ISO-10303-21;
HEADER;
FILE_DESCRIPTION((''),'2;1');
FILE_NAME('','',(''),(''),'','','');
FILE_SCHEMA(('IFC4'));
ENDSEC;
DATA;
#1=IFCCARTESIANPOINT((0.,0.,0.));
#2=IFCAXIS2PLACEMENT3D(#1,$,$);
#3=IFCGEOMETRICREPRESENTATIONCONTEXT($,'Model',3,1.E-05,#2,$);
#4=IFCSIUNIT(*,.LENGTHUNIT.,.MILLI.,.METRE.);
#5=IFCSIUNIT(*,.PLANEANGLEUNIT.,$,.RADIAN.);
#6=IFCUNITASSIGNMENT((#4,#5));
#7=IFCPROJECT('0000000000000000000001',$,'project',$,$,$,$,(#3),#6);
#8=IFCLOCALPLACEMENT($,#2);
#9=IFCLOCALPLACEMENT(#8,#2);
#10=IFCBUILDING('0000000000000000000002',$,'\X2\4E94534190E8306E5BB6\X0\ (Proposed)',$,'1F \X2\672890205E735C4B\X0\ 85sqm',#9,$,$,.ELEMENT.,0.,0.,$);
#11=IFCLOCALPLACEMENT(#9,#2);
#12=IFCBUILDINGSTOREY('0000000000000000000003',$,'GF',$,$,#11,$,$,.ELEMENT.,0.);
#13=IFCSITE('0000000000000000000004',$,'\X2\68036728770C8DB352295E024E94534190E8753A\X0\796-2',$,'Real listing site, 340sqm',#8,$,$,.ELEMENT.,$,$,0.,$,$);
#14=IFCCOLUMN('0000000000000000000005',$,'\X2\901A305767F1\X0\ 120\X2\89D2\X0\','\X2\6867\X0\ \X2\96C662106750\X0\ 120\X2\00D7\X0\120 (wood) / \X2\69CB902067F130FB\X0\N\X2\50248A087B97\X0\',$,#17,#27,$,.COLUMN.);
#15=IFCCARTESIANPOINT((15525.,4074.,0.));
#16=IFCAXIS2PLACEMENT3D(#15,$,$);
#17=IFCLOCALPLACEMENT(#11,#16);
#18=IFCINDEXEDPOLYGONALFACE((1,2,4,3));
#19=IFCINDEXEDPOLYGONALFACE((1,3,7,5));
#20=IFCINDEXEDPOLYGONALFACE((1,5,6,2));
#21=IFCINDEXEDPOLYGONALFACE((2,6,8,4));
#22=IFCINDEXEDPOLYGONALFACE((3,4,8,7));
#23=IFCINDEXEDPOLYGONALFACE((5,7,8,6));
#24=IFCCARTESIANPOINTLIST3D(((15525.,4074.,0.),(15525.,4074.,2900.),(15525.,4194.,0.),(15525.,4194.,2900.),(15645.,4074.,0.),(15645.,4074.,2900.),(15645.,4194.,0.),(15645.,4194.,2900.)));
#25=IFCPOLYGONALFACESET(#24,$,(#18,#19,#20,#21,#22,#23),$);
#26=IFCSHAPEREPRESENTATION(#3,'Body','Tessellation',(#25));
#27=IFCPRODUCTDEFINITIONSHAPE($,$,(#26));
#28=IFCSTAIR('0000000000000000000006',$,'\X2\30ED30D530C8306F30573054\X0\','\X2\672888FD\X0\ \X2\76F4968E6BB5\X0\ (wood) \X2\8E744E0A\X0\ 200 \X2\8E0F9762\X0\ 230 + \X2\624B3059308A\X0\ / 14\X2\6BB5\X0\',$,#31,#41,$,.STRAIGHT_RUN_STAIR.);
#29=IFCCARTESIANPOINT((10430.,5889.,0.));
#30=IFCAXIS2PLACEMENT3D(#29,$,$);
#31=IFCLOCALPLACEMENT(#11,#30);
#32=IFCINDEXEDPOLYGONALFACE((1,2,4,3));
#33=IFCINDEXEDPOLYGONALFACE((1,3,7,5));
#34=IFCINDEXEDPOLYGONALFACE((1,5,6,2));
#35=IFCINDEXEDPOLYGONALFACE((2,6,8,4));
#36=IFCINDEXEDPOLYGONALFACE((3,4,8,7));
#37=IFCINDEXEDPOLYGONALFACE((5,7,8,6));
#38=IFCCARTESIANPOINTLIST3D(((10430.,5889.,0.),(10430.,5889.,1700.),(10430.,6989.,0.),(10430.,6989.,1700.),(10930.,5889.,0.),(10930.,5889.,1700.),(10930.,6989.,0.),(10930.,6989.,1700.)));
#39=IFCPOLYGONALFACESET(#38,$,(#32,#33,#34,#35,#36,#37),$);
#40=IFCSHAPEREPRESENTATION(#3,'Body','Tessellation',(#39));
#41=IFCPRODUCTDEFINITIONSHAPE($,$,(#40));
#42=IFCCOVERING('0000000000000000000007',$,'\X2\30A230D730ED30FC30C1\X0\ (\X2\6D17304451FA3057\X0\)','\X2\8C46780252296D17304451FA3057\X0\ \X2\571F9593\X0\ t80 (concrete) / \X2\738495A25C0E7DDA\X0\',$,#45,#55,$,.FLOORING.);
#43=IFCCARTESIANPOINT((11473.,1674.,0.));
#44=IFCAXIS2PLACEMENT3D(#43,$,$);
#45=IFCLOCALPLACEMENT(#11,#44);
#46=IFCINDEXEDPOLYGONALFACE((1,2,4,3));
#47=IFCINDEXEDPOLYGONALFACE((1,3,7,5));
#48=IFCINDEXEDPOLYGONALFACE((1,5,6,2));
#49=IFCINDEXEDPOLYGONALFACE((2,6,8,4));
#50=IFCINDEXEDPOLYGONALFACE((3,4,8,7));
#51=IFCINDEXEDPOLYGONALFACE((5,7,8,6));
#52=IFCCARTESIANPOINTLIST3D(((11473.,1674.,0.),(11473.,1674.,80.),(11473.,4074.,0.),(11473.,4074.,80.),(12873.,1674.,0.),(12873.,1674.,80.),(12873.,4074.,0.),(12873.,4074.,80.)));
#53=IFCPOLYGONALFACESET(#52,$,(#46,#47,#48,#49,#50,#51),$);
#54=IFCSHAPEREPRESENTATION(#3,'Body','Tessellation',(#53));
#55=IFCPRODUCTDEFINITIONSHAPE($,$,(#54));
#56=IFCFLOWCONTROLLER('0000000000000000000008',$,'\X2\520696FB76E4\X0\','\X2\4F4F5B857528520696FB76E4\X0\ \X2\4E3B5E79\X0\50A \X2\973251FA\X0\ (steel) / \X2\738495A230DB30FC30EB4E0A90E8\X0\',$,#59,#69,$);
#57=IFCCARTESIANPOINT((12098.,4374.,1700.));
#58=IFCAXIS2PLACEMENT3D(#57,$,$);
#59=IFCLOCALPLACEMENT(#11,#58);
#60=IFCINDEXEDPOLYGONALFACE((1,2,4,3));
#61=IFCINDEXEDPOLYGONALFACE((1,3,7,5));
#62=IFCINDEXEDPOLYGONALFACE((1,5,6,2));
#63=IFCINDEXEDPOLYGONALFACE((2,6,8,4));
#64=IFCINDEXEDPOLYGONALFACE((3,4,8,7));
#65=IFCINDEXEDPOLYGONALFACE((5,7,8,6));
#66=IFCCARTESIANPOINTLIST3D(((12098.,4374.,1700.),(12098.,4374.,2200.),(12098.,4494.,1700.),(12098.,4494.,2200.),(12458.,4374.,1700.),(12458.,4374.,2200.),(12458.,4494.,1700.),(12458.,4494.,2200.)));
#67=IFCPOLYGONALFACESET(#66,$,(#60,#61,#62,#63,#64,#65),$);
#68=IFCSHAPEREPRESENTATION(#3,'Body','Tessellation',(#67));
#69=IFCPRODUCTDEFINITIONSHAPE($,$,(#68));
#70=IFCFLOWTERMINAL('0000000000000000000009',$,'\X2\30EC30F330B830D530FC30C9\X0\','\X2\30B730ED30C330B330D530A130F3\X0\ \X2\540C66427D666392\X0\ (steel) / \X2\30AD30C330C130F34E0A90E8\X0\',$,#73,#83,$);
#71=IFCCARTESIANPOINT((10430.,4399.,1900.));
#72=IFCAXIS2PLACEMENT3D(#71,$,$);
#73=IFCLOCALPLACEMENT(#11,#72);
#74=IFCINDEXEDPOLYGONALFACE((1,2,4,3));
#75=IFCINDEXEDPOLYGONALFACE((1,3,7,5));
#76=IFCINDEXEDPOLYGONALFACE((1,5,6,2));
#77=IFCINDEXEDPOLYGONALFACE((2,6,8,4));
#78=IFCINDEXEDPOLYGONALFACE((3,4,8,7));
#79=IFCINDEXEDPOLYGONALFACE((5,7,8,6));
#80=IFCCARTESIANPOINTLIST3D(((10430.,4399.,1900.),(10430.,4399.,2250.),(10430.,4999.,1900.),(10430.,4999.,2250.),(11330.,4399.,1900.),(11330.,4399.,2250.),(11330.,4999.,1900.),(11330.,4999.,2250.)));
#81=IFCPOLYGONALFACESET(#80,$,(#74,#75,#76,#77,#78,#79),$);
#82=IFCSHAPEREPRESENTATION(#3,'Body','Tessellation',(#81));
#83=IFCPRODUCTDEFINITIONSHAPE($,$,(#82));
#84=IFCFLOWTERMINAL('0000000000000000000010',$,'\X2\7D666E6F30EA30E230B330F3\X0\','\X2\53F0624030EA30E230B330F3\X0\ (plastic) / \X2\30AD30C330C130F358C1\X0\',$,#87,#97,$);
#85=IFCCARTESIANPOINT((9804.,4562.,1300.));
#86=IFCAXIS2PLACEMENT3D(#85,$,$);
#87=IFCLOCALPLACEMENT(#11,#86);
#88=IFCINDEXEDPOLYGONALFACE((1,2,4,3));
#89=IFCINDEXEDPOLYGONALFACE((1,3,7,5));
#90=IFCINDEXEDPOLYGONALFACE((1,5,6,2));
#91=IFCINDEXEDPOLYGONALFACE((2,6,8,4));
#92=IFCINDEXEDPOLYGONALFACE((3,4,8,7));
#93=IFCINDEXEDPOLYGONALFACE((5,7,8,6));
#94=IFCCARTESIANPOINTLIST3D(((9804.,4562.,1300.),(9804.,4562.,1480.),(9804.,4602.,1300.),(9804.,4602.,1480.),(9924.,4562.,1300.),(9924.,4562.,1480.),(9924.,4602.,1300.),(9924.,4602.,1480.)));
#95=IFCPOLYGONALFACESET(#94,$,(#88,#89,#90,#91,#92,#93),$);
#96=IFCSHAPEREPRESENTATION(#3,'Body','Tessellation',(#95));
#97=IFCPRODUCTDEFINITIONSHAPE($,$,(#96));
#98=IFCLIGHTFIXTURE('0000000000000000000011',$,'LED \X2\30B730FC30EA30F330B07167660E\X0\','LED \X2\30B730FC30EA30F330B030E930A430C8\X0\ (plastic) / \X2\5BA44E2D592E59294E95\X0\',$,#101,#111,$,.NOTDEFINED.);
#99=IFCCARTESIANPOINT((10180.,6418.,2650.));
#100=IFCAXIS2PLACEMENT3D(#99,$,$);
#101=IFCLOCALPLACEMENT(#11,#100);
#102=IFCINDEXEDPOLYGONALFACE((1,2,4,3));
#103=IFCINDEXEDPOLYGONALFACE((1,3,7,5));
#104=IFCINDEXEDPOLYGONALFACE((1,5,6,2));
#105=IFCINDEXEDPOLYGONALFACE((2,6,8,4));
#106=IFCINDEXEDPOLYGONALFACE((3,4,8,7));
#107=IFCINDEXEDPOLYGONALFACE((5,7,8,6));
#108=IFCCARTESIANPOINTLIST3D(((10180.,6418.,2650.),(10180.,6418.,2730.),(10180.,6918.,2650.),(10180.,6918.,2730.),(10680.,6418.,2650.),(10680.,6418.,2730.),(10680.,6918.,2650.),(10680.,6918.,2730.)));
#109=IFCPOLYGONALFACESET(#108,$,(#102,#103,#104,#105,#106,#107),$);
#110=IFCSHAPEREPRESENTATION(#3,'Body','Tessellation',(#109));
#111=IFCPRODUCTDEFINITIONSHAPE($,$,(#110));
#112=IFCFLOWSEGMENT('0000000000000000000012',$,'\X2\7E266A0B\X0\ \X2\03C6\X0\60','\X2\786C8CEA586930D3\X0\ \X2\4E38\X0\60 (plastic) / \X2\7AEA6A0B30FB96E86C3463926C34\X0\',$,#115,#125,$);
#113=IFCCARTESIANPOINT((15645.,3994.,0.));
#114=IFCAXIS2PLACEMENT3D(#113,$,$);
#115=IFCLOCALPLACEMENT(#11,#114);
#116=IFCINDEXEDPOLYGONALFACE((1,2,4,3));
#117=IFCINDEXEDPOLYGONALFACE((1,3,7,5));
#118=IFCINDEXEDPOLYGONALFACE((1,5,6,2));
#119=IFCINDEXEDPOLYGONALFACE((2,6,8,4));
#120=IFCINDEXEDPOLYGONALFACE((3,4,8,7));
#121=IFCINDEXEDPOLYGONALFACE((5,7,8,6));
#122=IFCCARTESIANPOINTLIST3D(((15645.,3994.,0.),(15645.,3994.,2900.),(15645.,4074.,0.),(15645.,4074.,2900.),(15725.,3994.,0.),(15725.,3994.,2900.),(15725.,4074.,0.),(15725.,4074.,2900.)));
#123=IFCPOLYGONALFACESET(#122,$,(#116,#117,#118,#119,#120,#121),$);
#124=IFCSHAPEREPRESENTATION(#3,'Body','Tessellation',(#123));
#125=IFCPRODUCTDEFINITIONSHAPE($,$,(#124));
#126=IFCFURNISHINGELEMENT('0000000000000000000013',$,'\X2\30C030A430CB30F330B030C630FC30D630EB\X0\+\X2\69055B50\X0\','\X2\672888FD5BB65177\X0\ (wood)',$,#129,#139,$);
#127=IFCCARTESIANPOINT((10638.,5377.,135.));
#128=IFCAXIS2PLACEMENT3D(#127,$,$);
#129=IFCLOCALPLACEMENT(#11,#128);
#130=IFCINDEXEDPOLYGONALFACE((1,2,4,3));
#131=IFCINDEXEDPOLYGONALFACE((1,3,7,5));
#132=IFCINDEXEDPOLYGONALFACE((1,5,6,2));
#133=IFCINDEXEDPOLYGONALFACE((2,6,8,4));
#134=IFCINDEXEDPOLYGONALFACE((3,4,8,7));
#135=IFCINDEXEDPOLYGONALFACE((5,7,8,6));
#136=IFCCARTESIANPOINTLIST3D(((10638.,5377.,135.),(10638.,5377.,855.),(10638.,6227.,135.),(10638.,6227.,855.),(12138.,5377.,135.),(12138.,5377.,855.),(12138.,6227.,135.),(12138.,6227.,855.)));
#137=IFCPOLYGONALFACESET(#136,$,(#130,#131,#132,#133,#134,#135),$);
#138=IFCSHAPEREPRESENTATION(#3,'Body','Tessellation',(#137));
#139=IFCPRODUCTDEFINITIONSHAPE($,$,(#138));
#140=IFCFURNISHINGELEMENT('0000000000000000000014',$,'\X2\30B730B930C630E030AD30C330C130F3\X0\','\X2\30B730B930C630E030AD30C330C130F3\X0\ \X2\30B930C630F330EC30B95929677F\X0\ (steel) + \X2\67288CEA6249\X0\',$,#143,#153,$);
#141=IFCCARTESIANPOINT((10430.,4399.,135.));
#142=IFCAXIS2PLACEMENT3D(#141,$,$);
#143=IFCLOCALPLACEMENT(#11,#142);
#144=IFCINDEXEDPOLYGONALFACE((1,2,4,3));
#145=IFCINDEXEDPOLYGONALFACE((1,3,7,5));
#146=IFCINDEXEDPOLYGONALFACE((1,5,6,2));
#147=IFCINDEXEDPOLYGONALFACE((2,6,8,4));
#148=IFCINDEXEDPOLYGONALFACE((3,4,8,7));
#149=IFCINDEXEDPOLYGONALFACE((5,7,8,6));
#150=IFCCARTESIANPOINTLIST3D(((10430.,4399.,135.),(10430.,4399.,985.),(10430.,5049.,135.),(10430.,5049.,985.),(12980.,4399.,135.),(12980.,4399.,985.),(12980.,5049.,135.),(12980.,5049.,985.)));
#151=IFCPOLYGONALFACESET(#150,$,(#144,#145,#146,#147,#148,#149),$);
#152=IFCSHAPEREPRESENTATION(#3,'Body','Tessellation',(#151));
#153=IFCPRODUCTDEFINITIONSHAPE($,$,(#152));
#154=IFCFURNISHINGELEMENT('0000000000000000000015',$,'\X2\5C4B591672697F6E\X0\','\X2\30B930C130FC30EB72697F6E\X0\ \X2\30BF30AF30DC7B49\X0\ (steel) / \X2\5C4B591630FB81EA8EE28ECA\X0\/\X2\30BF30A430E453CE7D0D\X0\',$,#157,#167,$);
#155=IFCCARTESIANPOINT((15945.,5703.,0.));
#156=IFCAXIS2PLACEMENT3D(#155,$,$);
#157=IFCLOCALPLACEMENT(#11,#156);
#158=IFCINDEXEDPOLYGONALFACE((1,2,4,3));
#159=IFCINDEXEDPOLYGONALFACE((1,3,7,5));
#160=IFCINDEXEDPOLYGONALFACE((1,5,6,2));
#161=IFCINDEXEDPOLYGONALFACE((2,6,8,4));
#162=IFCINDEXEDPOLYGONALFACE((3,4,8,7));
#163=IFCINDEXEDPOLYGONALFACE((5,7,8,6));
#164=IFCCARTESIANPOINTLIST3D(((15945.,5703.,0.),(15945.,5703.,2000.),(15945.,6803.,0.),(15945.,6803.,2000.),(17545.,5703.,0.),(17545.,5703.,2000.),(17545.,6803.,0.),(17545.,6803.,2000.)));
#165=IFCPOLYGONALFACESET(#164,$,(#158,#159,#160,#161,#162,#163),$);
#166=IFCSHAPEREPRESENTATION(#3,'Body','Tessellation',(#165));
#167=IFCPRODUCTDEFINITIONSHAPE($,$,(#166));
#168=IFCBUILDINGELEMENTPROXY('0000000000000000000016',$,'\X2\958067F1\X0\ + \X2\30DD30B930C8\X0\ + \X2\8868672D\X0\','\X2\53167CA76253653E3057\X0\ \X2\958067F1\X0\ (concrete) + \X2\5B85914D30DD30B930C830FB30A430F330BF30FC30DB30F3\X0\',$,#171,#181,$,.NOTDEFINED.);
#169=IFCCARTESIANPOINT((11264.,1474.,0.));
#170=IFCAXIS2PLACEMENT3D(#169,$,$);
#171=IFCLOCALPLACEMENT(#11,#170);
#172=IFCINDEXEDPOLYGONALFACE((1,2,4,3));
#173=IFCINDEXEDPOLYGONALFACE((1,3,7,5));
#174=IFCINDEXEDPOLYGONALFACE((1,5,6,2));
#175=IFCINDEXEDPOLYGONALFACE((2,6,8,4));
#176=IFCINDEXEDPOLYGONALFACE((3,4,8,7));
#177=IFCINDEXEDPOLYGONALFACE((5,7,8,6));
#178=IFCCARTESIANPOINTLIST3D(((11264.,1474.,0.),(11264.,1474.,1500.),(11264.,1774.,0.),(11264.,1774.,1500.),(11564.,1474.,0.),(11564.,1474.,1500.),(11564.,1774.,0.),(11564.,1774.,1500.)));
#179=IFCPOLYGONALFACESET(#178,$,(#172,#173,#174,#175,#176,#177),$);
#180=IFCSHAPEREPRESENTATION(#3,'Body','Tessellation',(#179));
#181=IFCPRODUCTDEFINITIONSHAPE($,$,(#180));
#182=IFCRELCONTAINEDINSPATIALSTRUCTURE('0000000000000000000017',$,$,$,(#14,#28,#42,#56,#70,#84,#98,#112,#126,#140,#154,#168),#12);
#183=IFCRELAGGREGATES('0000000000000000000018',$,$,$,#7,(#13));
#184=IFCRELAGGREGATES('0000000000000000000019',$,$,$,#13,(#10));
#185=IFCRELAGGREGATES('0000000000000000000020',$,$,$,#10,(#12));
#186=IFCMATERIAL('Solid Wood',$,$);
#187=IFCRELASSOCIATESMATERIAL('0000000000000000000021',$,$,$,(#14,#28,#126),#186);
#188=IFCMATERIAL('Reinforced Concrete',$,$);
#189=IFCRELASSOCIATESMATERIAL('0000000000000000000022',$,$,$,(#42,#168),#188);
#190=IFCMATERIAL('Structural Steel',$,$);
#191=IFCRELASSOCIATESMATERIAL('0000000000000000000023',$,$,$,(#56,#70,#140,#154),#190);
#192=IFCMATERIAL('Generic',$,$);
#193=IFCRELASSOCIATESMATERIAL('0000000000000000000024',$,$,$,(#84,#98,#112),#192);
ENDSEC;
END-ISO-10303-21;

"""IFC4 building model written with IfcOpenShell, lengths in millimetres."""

from ifc_helpers import new_model, si_unit, frame, frame_2d, origin, place, context, project, spatial, rectangle, extrude, material, element, save


model = new_model("IFC4")

# Units and contexts
model_context = context("Model", 3, precision=1e-05, world=origin())
ifc_project = project(units=[si_unit("LENGTHUNIT", "METRE", prefix="MILLI"), si_unit("PLANEANGLEUNIT", "RADIAN")], contexts=[model_context])

# Site, building, storey
site_placement = place(None, origin())
site = spatial("IfcSite", under=ifc_project, at=site_placement, Name="栃木県足利市五十部町796-2", ObjectType="Real listing site, 340sqm", CompositionType="ELEMENT", RefElevation=0.0)
building_placement = place(site_placement, origin())
building = spatial("IfcBuilding", under=site, at=building_placement, Name="五十部の家 (Proposed)", ObjectType="1F 木造平屋 85sqm", CompositionType="ELEMENT", ElevationOfRefHeight=0.0, ElevationOfTerrain=0.0)
storey_placement = place(building_placement, origin())
storey = spatial("IfcBuildingStorey", under=building, at=storey_placement, Name="GF", CompositionType="ELEMENT", Elevation=0.0)

# Column
ifc_material_1 = material(Name="Solid Wood")
column_1_placement = place(storey_placement, frame((15525.0, 4074.0, 0.0)))
element("IfcColumn", 1, at=column_1_placement, inside=storey, material=ifc_material_1, Name="通し柱 120角", Description="桧 集成材 120×120 (wood) / 構造柱・N値計算", PredefinedType="COLUMN", context=model_context, shape_type="SweptSolid", body=[
    extrude(rectangle(XDim=120.0, YDim=120.0, at=frame_2d((60.0, 60.0))), frame((15525.0, 4074.0, 0.0)), (0.0, 0.0, 1.0), 2900.0),
])

# Stair
stair_placement = place(storey_placement, frame((10430.0, 5889.0, 0.0)))
element("IfcStair", 2, at=stair_placement, inside=storey, material=ifc_material_1, Name="ロフトはしご", Description="木製 直階段 (wood) 蹴上 200 踏面 230 + 手すり / 14段", PredefinedType="STRAIGHT_RUN_STAIR", context=model_context, shape_type="SweptSolid", body=[
    extrude(rectangle(XDim=500.0, YDim=1100.0, at=frame_2d((250.0, 550.0))), frame((10430.0, 5889.0, 0.0)), (0.0, 0.0, 1.0), 1700.0),
])

# Covering
ifc_material_2 = material(Name="Reinforced Concrete")
covering_placement = place(storey_placement, frame((11473.0, 1674.0, 0.0)))
element("IfcCovering", 3, at=covering_placement, inside=storey, material=ifc_material_2, Name="アプローチ (洗い出し)", Description="豆砂利洗い出し 土間 t80 (concrete) / 玄関導線", PredefinedType="FLOORING", context=model_context, shape_type="SweptSolid", body=[
    extrude(rectangle(XDim=1400.0, YDim=2400.0, at=frame_2d((700.0, 1200.0))), frame((11473.0, 1674.0, 0.0)), (0.0, 0.0, 1.0), 80.0),
])

# Flow controller
ifc_material_3 = material(Name="Structural Steel")
flow_controller_placement = place(storey_placement, frame((12098.0, 4374.0, 1700.0)))
element("IfcFlowController", 4, at=flow_controller_placement, inside=storey, material=ifc_material_3, Name="分電盤", Description="住宅用分電盤 主幹50A 露出 (steel) / 玄関ホール上部", context=model_context, shape_type="SweptSolid", body=[
    extrude(rectangle(XDim=360.0, YDim=120.0, at=frame_2d((180.0, 60.0))), frame((12098.0, 4374.0, 1700.0)), (0.0, 0.0, 1.0), 500.0),
])

# Flow terminals
flow_terminal_1_placement = place(storey_placement, frame((10430.0, 4399.0, 1900.0)))
element("IfcFlowTerminal", 5, at=flow_terminal_1_placement, inside=storey, material=ifc_material_3, Name="レンジフード", Description="シロッコファン 同時給排 (steel) / キッチン上部", context=model_context, shape_type="SweptSolid", body=[
    extrude(rectangle(XDim=900.0, YDim=600.0, at=frame_2d((450.0, 300.0))), frame((10430.0, 4399.0, 1900.0)), (0.0, 0.0, 1.0), 350.0),
])
ifc_material_4 = material(Name="Generic")
flow_terminal_2_placement = place(storey_placement, frame((9804.0, 4562.0, 1300.0)))
element("IfcFlowTerminal", 6, at=flow_terminal_2_placement, inside=storey, material=ifc_material_4, Name="給湯リモコン", Description="台所リモコン (plastic) / キッチン壁", context=model_context, shape_type="SweptSolid", body=[
    extrude(rectangle(XDim=120.0, YDim=40.0, at=frame_2d((60.0, 20.0))), frame((9804.0, 4562.0, 1300.0)), (0.0, 0.0, 1.0), 180.0),
])

# Light fixture
light_fixture_placement = place(storey_placement, frame((10180.0, 6418.0, 2650.0)))
element("IfcLightFixture", 7, at=light_fixture_placement, inside=storey, material=ifc_material_4, Name="LED シーリング照明", Description="LED シーリングライト (plastic) / 室中央天井", PredefinedType="NOTDEFINED", context=model_context, shape_type="SweptSolid", body=[
    extrude(rectangle(XDim=500.0, YDim=500.0, at=frame_2d((250.0, 250.0))), frame((10180.0, 6418.0, 2650.0)), (0.0, 0.0, 1.0), 80.0),
])

# Flow segment
flow_segment_placement = place(storey_placement, frame((15645.0, 3994.0, 0.0)))
element("IfcFlowSegment", 8, at=flow_segment_placement, inside=storey, material=ifc_material_4, Name="縦樋 φ60", Description="硬質塩ビ 丸60 (plastic) / 竪樋・雨水排水", context=model_context, shape_type="SweptSolid", body=[
    extrude(rectangle(XDim=80.0, YDim=80.0, at=frame_2d((40.0, 40.0))), frame((15645.0, 3994.0, 0.0)), (0.0, 0.0, 1.0), 2900.0),
])

# Furnishing elements
furnishing_1_placement = place(storey_placement, frame((10638.0, 5377.0, 135.0)))
element("IfcFurnishingElement", 9, at=furnishing_1_placement, inside=storey, material=ifc_material_1, Name="ダイニングテーブル+椅子", Description="木製家具 (wood)", context=model_context, shape_type="SweptSolid", body=[
    extrude(rectangle(XDim=1500.0, YDim=850.0, at=frame_2d((750.0, 425.0))), frame((10638.0, 5377.0, 135.0)), (0.0, 0.0, 1.0), 720.0),
])
furnishing_2_placement = place(storey_placement, frame((10430.0, 4399.0, 135.0)))
element("IfcFurnishingElement", 10, at=furnishing_2_placement, inside=storey, material=ifc_material_3, Name="システムキッチン", Description="システムキッチン ステンレス天板 (steel) + 木質扉", context=model_context, shape_type="SweptSolid", body=[
    extrude(rectangle(XDim=2550.0, YDim=650.0, at=frame_2d((1275.0, 325.0))), frame((10430.0, 4399.0, 135.0)), (0.0, 0.0, 1.0), 850.0),
])
furnishing_3_placement = place(storey_placement, frame((15945.0, 5703.0, 0.0)))
element("IfcFurnishingElement", 11, at=furnishing_3_placement, inside=storey, material=ifc_material_3, Name="屋外物置", Description="スチール物置 タクボ等 (steel) / 屋外・自転車/タイヤ収納", context=model_context, shape_type="SweptSolid", body=[
    extrude(rectangle(XDim=1600.0, YDim=1100.0, at=frame_2d((800.0, 550.0))), frame((15945.0, 5703.0, 0.0)), (0.0, 0.0, 1.0), 2000.0),
])

# Building element proxy
proxy_placement = place(storey_placement, frame((11264.0, 1474.0, 0.0)))
element("IfcBuildingElementProxy", 12, at=proxy_placement, inside=storey, material=ifc_material_2, Name="門柱 + ポスト + 表札", Description="化粧打放し 門柱 (concrete) + 宅配ポスト・インターホン", PredefinedType="NOTDEFINED", context=model_context, shape_type="SweptSolid", body=[
    extrude(rectangle(XDim=300.0, YDim=300.0, at=frame_2d((150.0, 150.0))), frame((11264.0, 1474.0, 0.0)), (0.0, 0.0, 1.0), 1500.0),
])

save(model, "model.ifc")
